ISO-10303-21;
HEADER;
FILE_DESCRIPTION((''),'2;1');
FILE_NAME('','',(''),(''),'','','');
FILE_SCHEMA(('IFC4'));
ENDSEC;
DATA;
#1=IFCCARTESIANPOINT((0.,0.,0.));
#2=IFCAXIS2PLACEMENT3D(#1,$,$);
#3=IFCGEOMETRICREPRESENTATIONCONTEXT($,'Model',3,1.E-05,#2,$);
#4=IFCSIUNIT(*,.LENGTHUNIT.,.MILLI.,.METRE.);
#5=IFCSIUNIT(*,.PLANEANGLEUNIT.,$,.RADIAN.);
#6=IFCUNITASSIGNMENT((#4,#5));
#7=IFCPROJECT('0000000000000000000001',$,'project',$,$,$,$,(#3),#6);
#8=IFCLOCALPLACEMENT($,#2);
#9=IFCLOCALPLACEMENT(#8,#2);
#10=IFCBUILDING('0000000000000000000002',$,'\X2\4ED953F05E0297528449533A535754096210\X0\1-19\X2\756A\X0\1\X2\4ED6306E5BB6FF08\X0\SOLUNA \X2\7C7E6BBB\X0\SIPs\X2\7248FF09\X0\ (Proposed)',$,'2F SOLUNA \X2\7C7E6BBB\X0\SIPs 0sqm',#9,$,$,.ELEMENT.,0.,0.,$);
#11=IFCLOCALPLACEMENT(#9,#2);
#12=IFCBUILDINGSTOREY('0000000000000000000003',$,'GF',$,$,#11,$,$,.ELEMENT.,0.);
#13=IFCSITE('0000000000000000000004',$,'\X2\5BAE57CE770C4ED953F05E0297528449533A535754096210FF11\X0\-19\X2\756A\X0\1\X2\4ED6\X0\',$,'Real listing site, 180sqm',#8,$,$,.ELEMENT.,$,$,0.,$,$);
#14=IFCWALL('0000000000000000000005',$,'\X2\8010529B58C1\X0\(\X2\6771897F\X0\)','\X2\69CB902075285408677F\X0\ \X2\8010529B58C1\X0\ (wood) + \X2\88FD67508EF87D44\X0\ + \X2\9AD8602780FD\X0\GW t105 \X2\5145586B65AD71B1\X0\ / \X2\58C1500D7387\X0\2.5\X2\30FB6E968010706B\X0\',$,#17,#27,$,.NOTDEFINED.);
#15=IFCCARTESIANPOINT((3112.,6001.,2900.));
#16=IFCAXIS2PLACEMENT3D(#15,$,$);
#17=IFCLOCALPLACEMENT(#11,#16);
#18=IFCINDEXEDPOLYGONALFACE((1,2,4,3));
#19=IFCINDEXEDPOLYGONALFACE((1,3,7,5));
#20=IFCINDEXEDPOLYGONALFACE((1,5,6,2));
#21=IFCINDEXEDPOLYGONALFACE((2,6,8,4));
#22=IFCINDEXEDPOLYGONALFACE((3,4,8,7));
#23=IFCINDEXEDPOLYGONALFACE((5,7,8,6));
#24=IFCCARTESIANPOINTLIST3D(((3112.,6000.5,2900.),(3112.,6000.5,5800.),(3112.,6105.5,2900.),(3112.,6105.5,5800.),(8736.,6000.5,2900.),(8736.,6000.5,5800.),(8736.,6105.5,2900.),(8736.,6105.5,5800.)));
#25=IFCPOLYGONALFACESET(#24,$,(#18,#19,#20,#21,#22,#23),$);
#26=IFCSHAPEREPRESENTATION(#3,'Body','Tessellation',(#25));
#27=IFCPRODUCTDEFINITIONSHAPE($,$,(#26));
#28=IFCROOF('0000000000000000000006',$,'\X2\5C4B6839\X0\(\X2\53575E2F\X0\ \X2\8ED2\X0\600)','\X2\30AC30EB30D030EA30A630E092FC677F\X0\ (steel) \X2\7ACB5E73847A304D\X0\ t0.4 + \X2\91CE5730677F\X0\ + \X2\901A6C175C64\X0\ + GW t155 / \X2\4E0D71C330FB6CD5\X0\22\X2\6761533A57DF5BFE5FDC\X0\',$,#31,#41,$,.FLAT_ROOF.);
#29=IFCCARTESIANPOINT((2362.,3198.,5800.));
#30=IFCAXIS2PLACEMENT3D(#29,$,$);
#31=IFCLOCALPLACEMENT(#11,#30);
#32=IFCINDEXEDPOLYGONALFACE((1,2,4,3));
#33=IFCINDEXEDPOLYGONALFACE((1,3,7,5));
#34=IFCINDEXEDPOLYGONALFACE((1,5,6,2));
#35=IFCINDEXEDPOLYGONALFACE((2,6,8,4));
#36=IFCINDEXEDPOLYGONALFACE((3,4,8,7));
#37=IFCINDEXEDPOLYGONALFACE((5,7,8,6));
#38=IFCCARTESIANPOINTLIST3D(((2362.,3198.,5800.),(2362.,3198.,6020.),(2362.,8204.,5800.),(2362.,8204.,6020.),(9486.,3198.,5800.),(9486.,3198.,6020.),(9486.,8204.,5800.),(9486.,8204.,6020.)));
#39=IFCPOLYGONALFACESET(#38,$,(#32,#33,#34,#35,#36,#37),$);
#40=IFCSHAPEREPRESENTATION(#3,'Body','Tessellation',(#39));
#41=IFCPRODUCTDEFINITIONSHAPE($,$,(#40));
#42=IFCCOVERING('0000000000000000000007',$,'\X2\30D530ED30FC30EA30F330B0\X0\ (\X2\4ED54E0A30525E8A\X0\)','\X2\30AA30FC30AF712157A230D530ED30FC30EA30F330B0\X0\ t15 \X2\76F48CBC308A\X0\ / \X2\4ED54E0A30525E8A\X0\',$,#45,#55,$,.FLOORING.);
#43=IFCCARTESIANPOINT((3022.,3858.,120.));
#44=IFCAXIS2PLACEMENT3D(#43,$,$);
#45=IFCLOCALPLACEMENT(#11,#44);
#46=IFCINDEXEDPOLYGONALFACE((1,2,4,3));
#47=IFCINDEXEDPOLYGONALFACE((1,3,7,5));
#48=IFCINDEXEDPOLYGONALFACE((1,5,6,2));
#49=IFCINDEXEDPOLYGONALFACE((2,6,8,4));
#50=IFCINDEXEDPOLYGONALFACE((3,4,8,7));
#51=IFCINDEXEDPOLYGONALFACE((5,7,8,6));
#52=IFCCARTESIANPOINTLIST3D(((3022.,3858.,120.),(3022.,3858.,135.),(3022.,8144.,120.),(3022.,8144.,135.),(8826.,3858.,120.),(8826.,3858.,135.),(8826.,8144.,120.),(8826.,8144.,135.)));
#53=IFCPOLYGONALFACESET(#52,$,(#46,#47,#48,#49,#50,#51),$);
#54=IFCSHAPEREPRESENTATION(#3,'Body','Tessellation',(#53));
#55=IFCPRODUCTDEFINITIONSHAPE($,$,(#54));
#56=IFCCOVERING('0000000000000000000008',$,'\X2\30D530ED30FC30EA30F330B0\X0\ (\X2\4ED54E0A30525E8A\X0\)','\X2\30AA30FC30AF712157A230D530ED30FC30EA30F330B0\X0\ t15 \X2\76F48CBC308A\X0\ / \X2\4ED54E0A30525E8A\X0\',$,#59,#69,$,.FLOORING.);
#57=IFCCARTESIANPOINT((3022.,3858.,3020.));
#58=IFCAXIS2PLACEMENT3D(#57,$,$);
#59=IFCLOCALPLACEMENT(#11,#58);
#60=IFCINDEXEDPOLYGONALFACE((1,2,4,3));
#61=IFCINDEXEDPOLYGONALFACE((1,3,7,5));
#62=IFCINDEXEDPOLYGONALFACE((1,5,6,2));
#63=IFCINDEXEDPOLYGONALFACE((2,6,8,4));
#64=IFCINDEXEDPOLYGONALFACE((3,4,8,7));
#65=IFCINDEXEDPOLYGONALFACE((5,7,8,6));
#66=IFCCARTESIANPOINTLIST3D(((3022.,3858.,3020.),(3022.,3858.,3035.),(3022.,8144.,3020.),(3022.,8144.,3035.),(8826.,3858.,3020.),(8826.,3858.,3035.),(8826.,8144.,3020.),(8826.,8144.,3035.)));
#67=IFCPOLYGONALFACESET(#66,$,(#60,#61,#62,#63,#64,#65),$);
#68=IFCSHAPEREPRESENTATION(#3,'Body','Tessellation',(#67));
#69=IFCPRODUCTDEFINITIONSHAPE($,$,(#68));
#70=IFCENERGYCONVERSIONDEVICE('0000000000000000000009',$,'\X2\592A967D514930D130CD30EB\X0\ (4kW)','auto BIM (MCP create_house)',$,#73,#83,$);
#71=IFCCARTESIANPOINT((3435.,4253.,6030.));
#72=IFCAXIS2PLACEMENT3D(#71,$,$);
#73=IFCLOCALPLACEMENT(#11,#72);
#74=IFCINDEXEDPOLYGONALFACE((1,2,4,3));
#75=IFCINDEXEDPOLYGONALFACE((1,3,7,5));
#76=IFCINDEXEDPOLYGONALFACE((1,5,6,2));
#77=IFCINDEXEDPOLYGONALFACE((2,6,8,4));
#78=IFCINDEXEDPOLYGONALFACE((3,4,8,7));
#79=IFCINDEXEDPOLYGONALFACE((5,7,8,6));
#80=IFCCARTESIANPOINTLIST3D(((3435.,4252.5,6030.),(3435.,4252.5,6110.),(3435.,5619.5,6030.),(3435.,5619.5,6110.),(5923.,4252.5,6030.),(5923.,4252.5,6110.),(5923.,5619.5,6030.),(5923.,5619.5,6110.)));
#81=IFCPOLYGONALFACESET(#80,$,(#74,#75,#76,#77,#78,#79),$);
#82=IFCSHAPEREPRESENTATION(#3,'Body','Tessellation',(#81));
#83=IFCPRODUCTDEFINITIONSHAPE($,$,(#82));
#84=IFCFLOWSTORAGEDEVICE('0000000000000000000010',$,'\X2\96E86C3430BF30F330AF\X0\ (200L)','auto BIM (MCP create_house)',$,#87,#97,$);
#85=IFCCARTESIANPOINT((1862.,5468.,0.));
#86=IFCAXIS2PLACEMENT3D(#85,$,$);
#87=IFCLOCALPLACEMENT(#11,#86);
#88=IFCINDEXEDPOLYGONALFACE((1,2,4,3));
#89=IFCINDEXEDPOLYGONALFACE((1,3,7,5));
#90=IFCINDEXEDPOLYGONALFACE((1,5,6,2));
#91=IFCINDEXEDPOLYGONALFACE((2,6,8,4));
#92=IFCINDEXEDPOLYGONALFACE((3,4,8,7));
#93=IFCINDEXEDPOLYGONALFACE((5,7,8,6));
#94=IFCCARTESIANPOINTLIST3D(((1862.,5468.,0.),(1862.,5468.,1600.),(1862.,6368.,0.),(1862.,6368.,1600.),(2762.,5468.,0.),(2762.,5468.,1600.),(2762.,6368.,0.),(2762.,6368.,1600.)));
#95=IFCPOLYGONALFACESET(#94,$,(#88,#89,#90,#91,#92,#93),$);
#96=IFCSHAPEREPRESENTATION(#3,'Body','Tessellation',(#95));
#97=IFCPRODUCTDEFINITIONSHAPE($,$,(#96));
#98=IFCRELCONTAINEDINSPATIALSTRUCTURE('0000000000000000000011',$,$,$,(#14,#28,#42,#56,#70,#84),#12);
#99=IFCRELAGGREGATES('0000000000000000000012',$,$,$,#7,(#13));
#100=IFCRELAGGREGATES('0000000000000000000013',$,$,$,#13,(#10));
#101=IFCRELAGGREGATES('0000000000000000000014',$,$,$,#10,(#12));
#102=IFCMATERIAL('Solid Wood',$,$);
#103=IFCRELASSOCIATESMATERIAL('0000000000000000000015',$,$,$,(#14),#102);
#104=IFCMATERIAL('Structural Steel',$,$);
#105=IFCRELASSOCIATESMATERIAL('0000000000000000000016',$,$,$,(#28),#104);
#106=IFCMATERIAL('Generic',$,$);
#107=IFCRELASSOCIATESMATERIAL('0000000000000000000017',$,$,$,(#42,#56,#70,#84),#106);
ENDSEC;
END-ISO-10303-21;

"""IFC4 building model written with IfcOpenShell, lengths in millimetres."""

from ifc_helpers import new_model, si_unit, frame, frame_2d, origin, place, context, project, spatial, rectangle, extrude, material, element, save


model = new_model("IFC4")

# Units and contexts
model_context = context("Model", 3, precision=1e-05, world=origin())
ifc_project = project(units=[si_unit("LENGTHUNIT", "METRE", prefix="MILLI"), si_unit("PLANEANGLEUNIT", "RADIAN")], contexts=[model_context])

# Site, building, storey
site_placement = place(None, origin())
site = spatial("IfcSite", under=ifc_project, at=site_placement, Name="宮城県仙台市青葉区南吉成１-19番1他", ObjectType="Real listing site, 180sqm", CompositionType="ELEMENT", RefElevation=0.0)
building_placement = place(site_placement, origin())
building = spatial("IfcBuilding", under=site, at=building_placement, Name="仙台市青葉区南吉成1-19番1他の家（SOLUNA 籾殻SIPs版） (Proposed)", ObjectType="2F SOLUNA 籾殻SIPs 0sqm", CompositionType="ELEMENT", ElevationOfRefHeight=0.0, ElevationOfTerrain=0.0)
storey_placement = place(building_placement, origin())
storey = spatial("IfcBuildingStorey", under=building, at=storey_placement, Name="GF", CompositionType="ELEMENT", Elevation=0.0)

# Shared definitions
ifc_material_1 = material(Name="Solid Wood")

# Wall
wall_1_placement = place(storey_placement, frame((3112.0, 6001.0, 2900.0)))
element("IfcWall", 1, at=wall_1_placement, inside=storey, material=ifc_material_1, Name="耐力壁(東西)", Description="構造用合板 耐力壁 (wood) + 製材軸組 + 高性能GW t105 充填断熱 / 壁倍率2.5・準耐火", PredefinedType="NOTDEFINED", context=model_context, shape_type="SweptSolid", body=[
    extrude(rectangle(XDim=5624.0, YDim=105.0, at=frame_2d((2812.0, 52.0))), frame((3112.0, 6001.0, 2900.0)), (0.0, 0.0, 1.0), 2900.0),
])

# Roof
ifc_material_2 = material(Name="Structural Steel")
for number, where, name in (
    (2, (2362.0, 3198.0, 5800.0), "屋根(南帯 軒600)"),
):
    element("IfcRoof", number, at=place(storey_placement, frame(where)), inside=storey, material=ifc_material_2, Name=name, Description="ガルバリウム鋼板 (steel) 立平葺き t0.4 + 野地板 + 通気層 + GW t155 / 不燃・法22条区域対応", PredefinedType="FLAT_ROOF", context=model_context, shape_type="SweptSolid", body=[
        extrude(rectangle(XDim=7124.0, YDim=5006.0, at=frame_2d((3562.0, 2503.0))), frame((2362.0, 3198.0, 5800.0)), (0.0, 0.0, 1.0), 220.0),
    ])

# Coverings
ifc_material_3 = material(Name="Generic")
covering_1_placement = place(storey_placement, frame((3022.0, 3858.0, 120.0)))
element("IfcCovering", 3, at=covering_1_placement, inside=storey, material=ifc_material_3, Name="フローリング (仕上げ床)", Description="オーク無垢フローリング t15 直貼り / 仕上げ床", PredefinedType="FLOORING", context=model_context, shape_type="SweptSolid", body=[
    extrude(rectangle(XDim=5804.0, YDim=4286.0, at=frame_2d((2902.0, 2143.0))), frame((3022.0, 3858.0, 120.0)), (0.0, 0.0, 1.0), 15.0),
])
covering_2_placement = place(storey_placement, frame((3022.0, 3858.0, 3020.0)))
element("IfcCovering", 4, at=covering_2_placement, inside=storey, material=ifc_material_3, Name="フローリング (仕上げ床)", Description="オーク無垢フローリング t15 直貼り / 仕上げ床", PredefinedType="FLOORING", context=model_context, shape_type="SweptSolid", body=[
    extrude(rectangle(XDim=5804.0, YDim=4286.0, at=frame_2d((2902.0, 2143.0))), frame((3022.0, 3858.0, 3020.0)), (0.0, 0.0, 1.0), 15.0),
])

# Energy conversion device
energy_conversion_device_placement = place(storey_placement, frame((3435.0, 4253.0, 6030.0)))
element("IfcEnergyConversionDevice", 5, at=energy_conversion_device_placement, inside=storey, material=ifc_material_3, Name="太陽光パネル (4kW)", Description="auto BIM (MCP create_house)", context=model_context, shape_type="SweptSolid", body=[
    extrude(rectangle(XDim=2488.0, YDim=1367.0, at=frame_2d((1244.0, 683.0))), frame((3435.0, 4253.0, 6030.0)), (0.0, 0.0, 1.0), 80.0),
])

# Flow storage device
flow_storage_device_placement = place(storey_placement, frame((1862.0, 5468.0, 0.0)))
element("IfcFlowStorageDevice", 6, at=flow_storage_device_placement, inside=storey, material=ifc_material_3, Name="雨水タンク (200L)", Description="auto BIM (MCP create_house)", context=model_context, shape_type="SweptSolid", body=[
    extrude(rectangle(XDim=900.0, YDim=900.0, at=frame_2d((450.0, 450.0))), frame((1862.0, 5468.0, 0.0)), (0.0, 0.0, 1.0), 1600.0),
])

save(model, "model.ifc")
